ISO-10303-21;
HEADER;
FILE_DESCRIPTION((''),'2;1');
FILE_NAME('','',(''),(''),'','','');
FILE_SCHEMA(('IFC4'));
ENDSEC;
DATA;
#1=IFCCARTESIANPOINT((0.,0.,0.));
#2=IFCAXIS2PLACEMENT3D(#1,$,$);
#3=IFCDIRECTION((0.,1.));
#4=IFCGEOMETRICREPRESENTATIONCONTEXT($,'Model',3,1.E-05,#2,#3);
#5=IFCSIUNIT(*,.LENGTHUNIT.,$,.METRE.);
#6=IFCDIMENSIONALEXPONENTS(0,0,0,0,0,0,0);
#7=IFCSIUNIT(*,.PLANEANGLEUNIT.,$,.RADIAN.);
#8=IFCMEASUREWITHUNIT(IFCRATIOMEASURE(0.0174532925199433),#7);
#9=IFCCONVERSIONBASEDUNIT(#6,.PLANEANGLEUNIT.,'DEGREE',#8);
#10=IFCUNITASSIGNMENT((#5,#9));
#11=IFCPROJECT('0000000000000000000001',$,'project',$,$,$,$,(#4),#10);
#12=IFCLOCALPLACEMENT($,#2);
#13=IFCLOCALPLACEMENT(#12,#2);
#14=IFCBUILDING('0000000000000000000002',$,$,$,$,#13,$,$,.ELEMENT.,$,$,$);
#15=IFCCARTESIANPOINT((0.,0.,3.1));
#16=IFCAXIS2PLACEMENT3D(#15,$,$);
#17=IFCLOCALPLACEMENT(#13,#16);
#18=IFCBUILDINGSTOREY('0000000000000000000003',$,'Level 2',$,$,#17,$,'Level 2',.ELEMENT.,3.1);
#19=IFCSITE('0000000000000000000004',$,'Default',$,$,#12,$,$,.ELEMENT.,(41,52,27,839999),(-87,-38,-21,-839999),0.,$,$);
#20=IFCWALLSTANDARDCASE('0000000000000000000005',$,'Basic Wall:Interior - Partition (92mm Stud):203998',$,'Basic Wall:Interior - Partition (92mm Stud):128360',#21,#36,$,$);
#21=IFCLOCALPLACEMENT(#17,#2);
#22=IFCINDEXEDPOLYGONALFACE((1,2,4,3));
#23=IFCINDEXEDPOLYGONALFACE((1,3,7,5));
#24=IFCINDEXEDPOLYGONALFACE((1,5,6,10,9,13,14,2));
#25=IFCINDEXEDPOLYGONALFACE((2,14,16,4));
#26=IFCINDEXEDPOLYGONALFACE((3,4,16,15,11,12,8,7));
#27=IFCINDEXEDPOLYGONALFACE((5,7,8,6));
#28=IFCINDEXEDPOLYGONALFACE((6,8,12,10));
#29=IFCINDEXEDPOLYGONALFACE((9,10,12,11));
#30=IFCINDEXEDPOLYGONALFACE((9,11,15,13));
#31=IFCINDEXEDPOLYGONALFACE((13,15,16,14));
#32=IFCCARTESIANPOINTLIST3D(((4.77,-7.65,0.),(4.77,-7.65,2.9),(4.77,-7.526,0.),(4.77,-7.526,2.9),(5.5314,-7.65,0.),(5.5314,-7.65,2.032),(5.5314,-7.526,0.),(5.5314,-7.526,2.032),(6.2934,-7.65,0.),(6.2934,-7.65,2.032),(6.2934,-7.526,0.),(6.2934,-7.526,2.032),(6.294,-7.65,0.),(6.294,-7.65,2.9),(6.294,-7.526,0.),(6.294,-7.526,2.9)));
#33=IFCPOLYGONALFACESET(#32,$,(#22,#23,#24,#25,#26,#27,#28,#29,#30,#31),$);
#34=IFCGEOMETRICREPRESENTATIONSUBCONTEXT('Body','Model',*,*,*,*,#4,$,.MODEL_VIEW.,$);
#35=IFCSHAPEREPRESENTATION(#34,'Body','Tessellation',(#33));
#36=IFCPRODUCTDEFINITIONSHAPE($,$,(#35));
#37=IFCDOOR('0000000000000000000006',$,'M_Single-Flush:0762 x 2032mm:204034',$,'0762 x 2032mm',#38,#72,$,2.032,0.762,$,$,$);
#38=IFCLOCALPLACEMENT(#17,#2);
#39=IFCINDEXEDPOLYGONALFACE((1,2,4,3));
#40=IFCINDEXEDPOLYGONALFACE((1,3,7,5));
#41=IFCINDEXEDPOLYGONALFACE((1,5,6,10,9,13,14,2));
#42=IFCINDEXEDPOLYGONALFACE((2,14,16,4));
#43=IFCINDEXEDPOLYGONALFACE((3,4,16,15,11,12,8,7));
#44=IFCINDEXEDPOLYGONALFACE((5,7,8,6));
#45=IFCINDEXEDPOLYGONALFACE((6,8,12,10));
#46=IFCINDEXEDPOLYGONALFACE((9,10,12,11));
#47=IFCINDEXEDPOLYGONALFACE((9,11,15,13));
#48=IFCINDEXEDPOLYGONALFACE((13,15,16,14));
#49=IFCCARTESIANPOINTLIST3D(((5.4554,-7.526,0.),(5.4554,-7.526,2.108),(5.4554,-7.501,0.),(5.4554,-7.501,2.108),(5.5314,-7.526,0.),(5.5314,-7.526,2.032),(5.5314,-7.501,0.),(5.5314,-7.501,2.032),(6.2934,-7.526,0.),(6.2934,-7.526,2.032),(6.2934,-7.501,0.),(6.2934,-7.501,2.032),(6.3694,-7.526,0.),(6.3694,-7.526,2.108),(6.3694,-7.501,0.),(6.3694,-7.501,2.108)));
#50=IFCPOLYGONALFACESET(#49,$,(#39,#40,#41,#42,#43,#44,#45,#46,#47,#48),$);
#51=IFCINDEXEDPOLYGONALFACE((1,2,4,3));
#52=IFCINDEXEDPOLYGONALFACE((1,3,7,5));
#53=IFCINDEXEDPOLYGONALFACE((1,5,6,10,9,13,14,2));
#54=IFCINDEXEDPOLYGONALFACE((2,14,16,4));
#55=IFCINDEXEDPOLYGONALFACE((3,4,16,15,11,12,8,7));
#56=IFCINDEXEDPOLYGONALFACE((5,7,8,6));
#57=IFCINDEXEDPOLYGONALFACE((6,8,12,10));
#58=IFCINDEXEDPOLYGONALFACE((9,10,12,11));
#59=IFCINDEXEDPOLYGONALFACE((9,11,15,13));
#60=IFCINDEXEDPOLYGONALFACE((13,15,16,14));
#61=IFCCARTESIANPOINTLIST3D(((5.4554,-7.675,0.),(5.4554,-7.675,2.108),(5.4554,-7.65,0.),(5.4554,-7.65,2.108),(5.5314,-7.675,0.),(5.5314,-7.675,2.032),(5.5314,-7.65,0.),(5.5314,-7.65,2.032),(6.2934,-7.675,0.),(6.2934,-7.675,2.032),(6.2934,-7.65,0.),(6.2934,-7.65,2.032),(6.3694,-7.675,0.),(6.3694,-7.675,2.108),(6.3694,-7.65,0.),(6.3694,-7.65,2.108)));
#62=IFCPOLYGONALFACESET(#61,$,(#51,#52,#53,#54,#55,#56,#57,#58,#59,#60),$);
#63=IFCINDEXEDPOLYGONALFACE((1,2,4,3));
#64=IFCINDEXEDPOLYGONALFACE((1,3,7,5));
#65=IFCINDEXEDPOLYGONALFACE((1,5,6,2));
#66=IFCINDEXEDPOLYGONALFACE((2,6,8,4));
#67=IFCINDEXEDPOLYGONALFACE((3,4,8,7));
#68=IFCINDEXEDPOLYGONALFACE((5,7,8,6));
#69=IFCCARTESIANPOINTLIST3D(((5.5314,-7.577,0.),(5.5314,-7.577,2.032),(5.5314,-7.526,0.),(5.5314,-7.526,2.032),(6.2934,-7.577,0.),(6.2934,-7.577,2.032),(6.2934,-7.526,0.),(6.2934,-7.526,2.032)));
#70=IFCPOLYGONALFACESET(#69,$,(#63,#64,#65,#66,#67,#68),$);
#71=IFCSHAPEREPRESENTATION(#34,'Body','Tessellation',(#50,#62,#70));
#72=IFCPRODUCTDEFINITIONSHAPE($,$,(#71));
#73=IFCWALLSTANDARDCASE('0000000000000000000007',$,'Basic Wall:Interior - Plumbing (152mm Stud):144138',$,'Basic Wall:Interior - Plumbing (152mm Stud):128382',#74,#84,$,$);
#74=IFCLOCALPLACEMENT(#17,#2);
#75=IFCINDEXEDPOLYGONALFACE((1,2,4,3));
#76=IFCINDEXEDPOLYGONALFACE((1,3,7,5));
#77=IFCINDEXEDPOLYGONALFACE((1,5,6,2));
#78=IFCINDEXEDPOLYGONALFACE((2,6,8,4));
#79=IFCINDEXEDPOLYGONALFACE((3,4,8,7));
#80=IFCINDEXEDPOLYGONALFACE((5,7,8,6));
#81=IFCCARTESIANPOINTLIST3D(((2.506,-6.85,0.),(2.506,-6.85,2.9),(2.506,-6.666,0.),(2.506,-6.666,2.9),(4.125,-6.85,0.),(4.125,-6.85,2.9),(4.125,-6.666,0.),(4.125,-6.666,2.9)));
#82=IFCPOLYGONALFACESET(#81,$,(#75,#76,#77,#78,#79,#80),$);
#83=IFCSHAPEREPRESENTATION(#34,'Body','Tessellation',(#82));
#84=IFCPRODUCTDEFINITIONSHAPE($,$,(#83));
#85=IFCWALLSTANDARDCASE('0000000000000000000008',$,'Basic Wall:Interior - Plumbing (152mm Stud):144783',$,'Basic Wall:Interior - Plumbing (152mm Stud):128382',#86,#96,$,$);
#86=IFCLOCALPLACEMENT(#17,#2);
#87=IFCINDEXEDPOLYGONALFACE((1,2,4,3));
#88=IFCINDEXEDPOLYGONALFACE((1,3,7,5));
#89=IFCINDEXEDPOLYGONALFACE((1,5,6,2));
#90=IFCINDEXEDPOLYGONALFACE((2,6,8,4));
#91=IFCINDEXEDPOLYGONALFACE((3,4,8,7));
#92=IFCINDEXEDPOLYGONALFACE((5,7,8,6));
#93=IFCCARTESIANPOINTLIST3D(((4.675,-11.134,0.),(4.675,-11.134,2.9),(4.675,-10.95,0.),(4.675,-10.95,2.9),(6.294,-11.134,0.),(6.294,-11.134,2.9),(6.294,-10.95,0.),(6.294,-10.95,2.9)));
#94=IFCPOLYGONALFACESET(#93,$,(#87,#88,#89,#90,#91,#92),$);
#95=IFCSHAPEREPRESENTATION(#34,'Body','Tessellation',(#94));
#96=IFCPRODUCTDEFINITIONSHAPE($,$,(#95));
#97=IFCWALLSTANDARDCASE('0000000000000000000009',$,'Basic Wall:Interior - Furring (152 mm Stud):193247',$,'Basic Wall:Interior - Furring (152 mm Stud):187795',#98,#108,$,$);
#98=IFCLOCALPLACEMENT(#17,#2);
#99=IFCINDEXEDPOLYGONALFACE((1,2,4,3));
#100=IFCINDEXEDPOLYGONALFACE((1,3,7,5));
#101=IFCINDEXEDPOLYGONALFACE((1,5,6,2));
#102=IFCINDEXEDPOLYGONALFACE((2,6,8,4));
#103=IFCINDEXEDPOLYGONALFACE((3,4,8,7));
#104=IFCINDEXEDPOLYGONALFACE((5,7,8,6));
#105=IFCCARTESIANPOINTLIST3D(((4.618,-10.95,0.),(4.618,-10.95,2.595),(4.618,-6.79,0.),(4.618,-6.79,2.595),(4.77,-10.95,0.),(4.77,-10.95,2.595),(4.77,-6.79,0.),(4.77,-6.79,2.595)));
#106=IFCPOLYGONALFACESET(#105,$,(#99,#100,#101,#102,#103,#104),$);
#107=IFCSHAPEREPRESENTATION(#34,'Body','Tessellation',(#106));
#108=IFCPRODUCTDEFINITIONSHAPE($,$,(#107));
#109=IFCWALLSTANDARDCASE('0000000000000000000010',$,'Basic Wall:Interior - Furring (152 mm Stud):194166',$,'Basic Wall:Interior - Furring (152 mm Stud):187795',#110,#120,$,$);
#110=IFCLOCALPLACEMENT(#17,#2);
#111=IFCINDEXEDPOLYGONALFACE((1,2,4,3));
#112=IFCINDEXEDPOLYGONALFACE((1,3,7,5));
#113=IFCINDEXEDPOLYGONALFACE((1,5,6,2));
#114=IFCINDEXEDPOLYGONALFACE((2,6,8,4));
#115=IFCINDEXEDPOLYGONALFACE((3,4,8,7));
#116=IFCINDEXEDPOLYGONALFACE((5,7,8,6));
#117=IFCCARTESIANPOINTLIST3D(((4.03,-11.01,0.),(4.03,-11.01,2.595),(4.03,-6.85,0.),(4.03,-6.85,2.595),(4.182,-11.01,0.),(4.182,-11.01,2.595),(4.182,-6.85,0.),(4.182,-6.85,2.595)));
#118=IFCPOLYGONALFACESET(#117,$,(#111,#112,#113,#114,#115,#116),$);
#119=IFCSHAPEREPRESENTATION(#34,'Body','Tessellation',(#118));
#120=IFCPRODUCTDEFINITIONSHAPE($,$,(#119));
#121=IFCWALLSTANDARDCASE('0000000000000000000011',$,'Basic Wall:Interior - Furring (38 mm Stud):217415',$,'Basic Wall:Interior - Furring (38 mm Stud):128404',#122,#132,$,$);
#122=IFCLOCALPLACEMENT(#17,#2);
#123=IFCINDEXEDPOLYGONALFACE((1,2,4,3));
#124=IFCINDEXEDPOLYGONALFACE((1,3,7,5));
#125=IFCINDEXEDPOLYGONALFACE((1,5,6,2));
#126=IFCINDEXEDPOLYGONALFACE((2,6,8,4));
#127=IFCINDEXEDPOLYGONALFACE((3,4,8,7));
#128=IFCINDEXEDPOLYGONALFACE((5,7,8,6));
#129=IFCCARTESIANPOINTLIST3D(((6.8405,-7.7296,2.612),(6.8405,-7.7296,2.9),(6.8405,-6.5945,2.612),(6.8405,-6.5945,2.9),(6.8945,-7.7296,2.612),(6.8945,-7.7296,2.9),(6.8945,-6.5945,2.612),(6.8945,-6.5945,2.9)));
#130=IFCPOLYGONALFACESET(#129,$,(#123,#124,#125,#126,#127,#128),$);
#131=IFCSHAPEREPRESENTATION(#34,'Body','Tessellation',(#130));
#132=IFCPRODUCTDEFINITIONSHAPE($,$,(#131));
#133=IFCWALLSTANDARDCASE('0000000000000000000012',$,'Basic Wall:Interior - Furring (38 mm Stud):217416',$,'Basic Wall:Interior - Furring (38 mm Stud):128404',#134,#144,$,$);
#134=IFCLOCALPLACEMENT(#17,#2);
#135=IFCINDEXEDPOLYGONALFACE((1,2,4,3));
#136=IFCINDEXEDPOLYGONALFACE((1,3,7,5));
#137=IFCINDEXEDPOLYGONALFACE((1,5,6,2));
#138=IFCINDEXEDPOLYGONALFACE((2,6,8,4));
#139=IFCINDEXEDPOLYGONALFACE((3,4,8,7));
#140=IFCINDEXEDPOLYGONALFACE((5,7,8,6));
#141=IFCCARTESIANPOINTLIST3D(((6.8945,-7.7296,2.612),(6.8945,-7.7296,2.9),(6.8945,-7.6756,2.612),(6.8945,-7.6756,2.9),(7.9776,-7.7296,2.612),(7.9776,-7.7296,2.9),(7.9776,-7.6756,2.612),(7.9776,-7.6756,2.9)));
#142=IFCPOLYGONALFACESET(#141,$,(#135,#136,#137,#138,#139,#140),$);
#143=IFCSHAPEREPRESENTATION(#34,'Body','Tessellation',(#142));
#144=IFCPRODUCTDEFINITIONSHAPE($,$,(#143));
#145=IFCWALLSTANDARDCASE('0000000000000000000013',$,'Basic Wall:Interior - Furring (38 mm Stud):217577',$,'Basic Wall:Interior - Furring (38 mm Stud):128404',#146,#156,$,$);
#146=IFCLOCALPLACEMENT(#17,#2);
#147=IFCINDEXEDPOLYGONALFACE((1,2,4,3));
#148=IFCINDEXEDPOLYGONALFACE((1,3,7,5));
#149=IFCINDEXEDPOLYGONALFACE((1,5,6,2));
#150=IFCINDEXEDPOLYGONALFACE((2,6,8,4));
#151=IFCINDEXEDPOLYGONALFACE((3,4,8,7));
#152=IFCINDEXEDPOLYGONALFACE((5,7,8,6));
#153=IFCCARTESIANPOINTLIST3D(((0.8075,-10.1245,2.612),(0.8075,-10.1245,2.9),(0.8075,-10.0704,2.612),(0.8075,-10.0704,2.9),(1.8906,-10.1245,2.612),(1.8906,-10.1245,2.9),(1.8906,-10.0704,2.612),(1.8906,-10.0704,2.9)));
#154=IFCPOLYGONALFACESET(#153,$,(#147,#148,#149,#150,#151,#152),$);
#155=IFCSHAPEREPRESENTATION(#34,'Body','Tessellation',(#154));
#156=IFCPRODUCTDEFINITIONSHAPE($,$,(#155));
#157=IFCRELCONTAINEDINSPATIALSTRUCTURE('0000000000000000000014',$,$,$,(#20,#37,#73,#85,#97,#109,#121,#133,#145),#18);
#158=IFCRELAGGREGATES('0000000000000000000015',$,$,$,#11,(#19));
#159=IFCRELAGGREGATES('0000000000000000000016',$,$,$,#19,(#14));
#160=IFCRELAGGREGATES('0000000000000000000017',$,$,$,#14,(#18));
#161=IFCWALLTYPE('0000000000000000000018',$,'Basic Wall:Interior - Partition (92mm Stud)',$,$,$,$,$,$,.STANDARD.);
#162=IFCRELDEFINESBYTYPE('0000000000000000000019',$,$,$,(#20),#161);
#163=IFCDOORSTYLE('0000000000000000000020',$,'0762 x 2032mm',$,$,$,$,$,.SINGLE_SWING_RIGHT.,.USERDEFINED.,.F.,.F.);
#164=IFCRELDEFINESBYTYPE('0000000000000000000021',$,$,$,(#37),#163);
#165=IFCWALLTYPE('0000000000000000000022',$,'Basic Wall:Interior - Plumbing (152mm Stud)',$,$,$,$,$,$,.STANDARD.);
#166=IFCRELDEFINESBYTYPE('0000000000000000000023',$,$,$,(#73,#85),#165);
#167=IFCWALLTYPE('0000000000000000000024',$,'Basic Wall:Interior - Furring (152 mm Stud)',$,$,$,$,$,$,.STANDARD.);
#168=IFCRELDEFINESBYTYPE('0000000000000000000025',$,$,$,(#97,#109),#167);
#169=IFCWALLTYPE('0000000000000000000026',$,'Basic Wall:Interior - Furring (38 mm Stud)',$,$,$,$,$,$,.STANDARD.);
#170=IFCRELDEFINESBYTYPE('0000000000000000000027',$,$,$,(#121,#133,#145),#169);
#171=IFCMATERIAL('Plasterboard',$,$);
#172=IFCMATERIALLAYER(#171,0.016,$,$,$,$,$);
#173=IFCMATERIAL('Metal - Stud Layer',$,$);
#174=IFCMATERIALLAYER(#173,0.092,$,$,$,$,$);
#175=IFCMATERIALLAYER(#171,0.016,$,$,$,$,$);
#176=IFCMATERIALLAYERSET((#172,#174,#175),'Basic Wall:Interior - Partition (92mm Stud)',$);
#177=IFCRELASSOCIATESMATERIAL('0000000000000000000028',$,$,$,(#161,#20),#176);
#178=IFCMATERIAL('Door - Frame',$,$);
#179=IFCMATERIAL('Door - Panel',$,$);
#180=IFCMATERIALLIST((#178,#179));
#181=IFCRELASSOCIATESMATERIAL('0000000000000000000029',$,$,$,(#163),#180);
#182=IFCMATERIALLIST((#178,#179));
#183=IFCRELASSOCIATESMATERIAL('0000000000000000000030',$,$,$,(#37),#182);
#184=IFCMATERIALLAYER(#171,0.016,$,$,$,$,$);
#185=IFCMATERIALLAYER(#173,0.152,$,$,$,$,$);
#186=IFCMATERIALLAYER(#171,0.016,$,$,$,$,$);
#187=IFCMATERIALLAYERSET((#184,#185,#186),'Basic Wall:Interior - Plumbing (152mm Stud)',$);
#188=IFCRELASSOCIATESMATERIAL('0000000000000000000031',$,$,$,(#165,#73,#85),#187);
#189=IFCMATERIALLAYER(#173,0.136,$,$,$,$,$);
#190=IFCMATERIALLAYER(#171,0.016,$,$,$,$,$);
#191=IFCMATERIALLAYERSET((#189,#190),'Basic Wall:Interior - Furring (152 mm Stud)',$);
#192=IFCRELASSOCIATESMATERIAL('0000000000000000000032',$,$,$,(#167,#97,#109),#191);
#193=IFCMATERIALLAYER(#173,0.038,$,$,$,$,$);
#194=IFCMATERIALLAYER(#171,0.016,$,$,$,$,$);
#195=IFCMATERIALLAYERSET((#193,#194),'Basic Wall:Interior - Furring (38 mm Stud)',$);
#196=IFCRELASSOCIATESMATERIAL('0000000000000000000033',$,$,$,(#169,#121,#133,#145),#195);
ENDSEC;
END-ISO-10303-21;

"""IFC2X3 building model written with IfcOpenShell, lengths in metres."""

from ifc_helpers import new_model, entity, si_unit, converted_unit, direction, frame, frame_2d, origin, origin_2d_with_axis, place, context, subcontext, project, spatial, polyline, rectangle, outline, extrude, source, transform, mapped, material, material_list, layer, layer_set, layer_usage, type_object, type_shapes, element, fill, save


model = new_model("IFC2X3")

# Units and contexts
model_context = context("Model", 3, precision=1e-05, world=origin(), true_north=direction((0.0, 1.0)))
body_context = subcontext(model_context, "Body", "Model", "MODEL_VIEW")
ifc_project = project(units=[si_unit("LENGTHUNIT", "METRE"), converted_unit("PLANEANGLEUNIT", "DEGREE", entity("IfcRatioMeasure", 0.0174532925199433), si_unit("PLANEANGLEUNIT", "RADIAN"), dimensions=[0, 0, 0, 0, 0, 0, 0])], contexts=[model_context])

# Site, building, storey
site_placement = place(None, origin())
site = spatial("IfcSite", under=ifc_project, at=site_placement, Name="Default", CompositionType="ELEMENT", RefLatitude=(41, 52, 27, 839999), RefLongitude=(-87, -38, -21, -839999), RefElevation=0.0)
building_placement = place(site_placement, origin())
building = spatial("IfcBuilding", under=site, at=building_placement, CompositionType="ELEMENT")
storey_placement = place(building_placement, frame((0.0, 0.0, 3.1)))
storey = spatial("IfcBuildingStorey", under=building, at=storey_placement, Name="Level 2", LongName="Level 2", CompositionType="ELEMENT", Elevation=3.1)

# Shared definitions
ifc_material_1 = material(Name="Plasterboard")
ifc_layer_1 = layer(ifc_material_1, 0.016)
ifc_material_2 = material(Name="Metal - Stud Layer")
ifc_layer_2 = layer(ifc_material_2, 0.092)
ifc_layer_3 = layer(ifc_material_1, 0.016)
ifc_layer_set_1 = layer_set([ifc_layer_1, ifc_layer_2, ifc_layer_3], Name="Basic Wall:Interior - Partition (92mm Stud)")
wall_type_1 = type_object("IfcWallType", Name="Basic Wall:Interior - Partition (92mm Stud)", PredefinedType="STANDARD", material=ifc_layer_set_1)

# Wall, opening, door
ifc_material_3 = material(Name="Door - Frame")
ifc_material_4 = material(Name="Door - Panel")
ifc_material_list_1 = material_list([ifc_material_3, ifc_material_4])
door_style = type_object("IfcDoorStyle", Name="0762 x 2032mm", ConstructionType="USERDEFINED", OperationType="SINGLE_SWING_RIGHT", ParameterTakesPrecedence=False, Sizeable=False, material=ifc_material_list_1)
shared_shape_1 = source(origin(), body_context, "Body", "SweptSolid", [
    extrude(outline(polyline([(-0.457, -1.073), (0.457, -1.073), (0.457, 1.035), (0.381, 1.035), (0.381, -0.997), (-0.381, -0.997), (-0.381, 1.035), (-0.457, 1.035), (-0.457, -1.073)])), frame((0.381, 0.124, 1.035), z_axis=(0.0, 1.0, 0.0), x_axis=(1.0, 0.0, 0.0)), (0.0, 0.0, 1.0), 0.025),
    extrude(outline(polyline([(-1.073, -0.457), (1.035, -0.457), (1.035, -0.381), (-0.997, -0.381), (-0.997, 0.381), (1.035, 0.381), (1.035, 0.457), (-1.073, 0.457), (-1.073, -0.457)])), frame((0.381, -0.025, 1.035), z_axis=(0.0, 1.0, 0.0), x_axis=(0.0, 0.0, -1.0)), (0.0, 0.0, 1.0), 0.025),
    extrude(rectangle(XDim=0.051, YDim=0.762, at=origin_2d_with_axis()), frame((0.381, 0.0985, 0.0), z_axis=(0.0, 0.0, 1.0), x_axis=(0.0, 1.0, 0.0)), (0.0, 0.0, 1.0), 2.032),
])
type_shapes(door_style, [shared_shape_1])
ifc_layer_usage_1 = layer_usage(ifc_layer_set_1, "AXIS2", "POSITIVE", -0.062)
wall_1_placement = place(storey_placement, frame((4.77, -7.588, 0.0)))
wall_1 = element("IfcWallStandardCase", 1, at=wall_1_placement, inside=storey, type_object=wall_type_1, material=ifc_layer_usage_1, Name="Basic Wall:Interior - Partition (92mm Stud):203998", ObjectType="Basic Wall:Interior - Partition (92mm Stud):128360", context=body_context, shape_type="SweptSolid", body=[
    extrude(rectangle(XDim=1.524, YDim=0.124, at=frame_2d((0.762, 0.0), x_axis=(-1.0, 0.0))), origin(), (0.0, 0.0, 1.0), 2.9),
])
opening_1_placement = place(wall_1_placement, frame((0.7614, -0.062, 0.0)))
opening_1 = element("IfcOpeningElement", 2, at=opening_1_placement, cuts=wall_1, ObjectType="Opening", context=body_context, shape_type="SweptSolid", body=[
    extrude(rectangle(XDim=0.762, YDim=2.032, at=frame_2d((1.016, 0.381), x_axis=(0.0, 1.0))), frame((0.0, 0.0, 0.0), z_axis=(0.0, 1.0, 0.0), x_axis=(0.0, 0.0, 1.0)), (0.0, 0.0, 1.0), 0.124),
])
ifc_material_list_2 = material_list([ifc_material_3, ifc_material_4])
door_1_placement = place(opening_1_placement, origin())
door_1 = element("IfcDoor", 3, at=door_1_placement, inside=storey, type_object=door_style, material=ifc_material_list_2, Name="M_Single-Flush:0762 x 2032mm:204034", ObjectType="0762 x 2032mm", OverallHeight=2.032, OverallWidth=0.762, context=body_context, shape_type="MappedRepresentation", body=[
    mapped(shared_shape_1, transform((0.0, 0.0, 0.0), scale=1.0)),
])
fill(opening_1, door_1)

# Walls
ifc_layer_4 = layer(ifc_material_1, 0.016)
ifc_layer_5 = layer(ifc_material_2, 0.152)
ifc_layer_6 = layer(ifc_material_1, 0.016)
ifc_layer_set_2 = layer_set([ifc_layer_4, ifc_layer_5, ifc_layer_6], Name="Basic Wall:Interior - Plumbing (152mm Stud)")
ifc_layer_usage_2 = layer_usage(ifc_layer_set_2, "AXIS2", "NEGATIVE", 0.092)
wall_type_2 = type_object("IfcWallType", Name="Basic Wall:Interior - Plumbing (152mm Stud)", PredefinedType="STANDARD", material=ifc_layer_set_2)
wall_2_placement = place(storey_placement, frame((2.506, -6.758, 0.0)))
element("IfcWallStandardCase", 4, at=wall_2_placement, inside=storey, type_object=wall_type_2, material=ifc_layer_usage_2, Name="Basic Wall:Interior - Plumbing (152mm Stud):144138", ObjectType="Basic Wall:Interior - Plumbing (152mm Stud):128382", context=body_context, shape_type="SweptSolid", body=[
    extrude(rectangle(XDim=1.619, YDim=0.184, at=frame_2d((0.8095, 0.0), x_axis=(-1.0, 0.0))), origin(), (0.0, 0.0, 1.0), 2.9),
])
ifc_layer_usage_3 = layer_usage(ifc_layer_set_2, "AXIS2", "NEGATIVE", 0.092)
wall_3_placement = place(storey_placement, frame((6.294, -11.042, 0.0), z_axis=(0.0, 0.0, 1.0), x_axis=(-1.0, 0.0, 0.0)))
element("IfcWallStandardCase", 5, at=wall_3_placement, inside=storey, type_object=wall_type_2, material=ifc_layer_usage_3, Name="Basic Wall:Interior - Plumbing (152mm Stud):144783", ObjectType="Basic Wall:Interior - Plumbing (152mm Stud):128382", context=body_context, shape_type="SweptSolid", body=[
    extrude(rectangle(XDim=1.619, YDim=0.184, at=frame_2d((0.8095, 0.0), x_axis=(-1.0, 0.0))), origin(), (0.0, 0.0, 1.0), 2.9),
])
ifc_layer_7 = layer(ifc_material_2, 0.136)
ifc_layer_8 = layer(ifc_material_1, 0.016)
ifc_layer_set_3 = layer_set([ifc_layer_7, ifc_layer_8], Name="Basic Wall:Interior - Furring (152 mm Stud)")
ifc_layer_usage_4 = layer_usage(ifc_layer_set_3, "AXIS2", "POSITIVE", -0.076)
wall_type_3 = type_object("IfcWallType", Name="Basic Wall:Interior - Furring (152 mm Stud)", PredefinedType="STANDARD", material=ifc_layer_set_3)
wall_4_placement = place(storey_placement, frame((4.694, -6.79, 0.0), z_axis=(0.0, 0.0, 1.0), x_axis=(0.0, -1.0, 0.0)))
element("IfcWallStandardCase", 6, at=wall_4_placement, inside=storey, type_object=wall_type_3, material=ifc_layer_usage_4, Name="Basic Wall:Interior - Furring (152 mm Stud):193247", ObjectType="Basic Wall:Interior - Furring (152 mm Stud):187795", context=body_context, shape_type="SweptSolid", body=[
    extrude(rectangle(XDim=4.16, YDim=0.152, at=frame_2d((2.08, 0.0), x_axis=(-1.0, 0.0))), origin(), (0.0, 0.0, 1.0), 2.595),
])
ifc_layer_usage_5 = layer_usage(ifc_layer_set_3, "AXIS2", "POSITIVE", -0.076)
wall_5_placement = place(storey_placement, frame((4.106, -11.01, 0.0), z_axis=(0.0, 0.0, 1.0), x_axis=(0.0, 1.0, 0.0)))
element("IfcWallStandardCase", 7, at=wall_5_placement, inside=storey, type_object=wall_type_3, material=ifc_layer_usage_5, Name="Basic Wall:Interior - Furring (152 mm Stud):194166", ObjectType="Basic Wall:Interior - Furring (152 mm Stud):187795", context=body_context, shape_type="SweptSolid", body=[
    extrude(rectangle(XDim=4.16, YDim=0.152, at=frame_2d((2.08, 0.0), x_axis=(-1.0, 0.0))), origin(), (0.0, 0.0, 1.0), 2.595),
])
ifc_layer_9 = layer(ifc_material_2, 0.038)
ifc_layer_10 = layer(ifc_material_1, 0.016)
ifc_layer_set_4 = layer_set([ifc_layer_9, ifc_layer_10], Name="Basic Wall:Interior - Furring (38 mm Stud)")
ifc_layer_usage_6 = layer_usage(ifc_layer_set_4, "AXIS2", "NEGATIVE", 0.027)
wall_type_4 = type_object("IfcWallType", Name="Basic Wall:Interior - Furring (38 mm Stud)", PredefinedType="STANDARD", material=ifc_layer_set_4)
wall_6_placement = place(storey_placement, frame((6.8675, -7.7296, 2.612), z_axis=(0.0, 0.0, 1.0), x_axis=(0.0, 1.0, 0.0)))
element("IfcWallStandardCase", 8, at=wall_6_placement, inside=storey, type_object=wall_type_4, material=ifc_layer_usage_6, Name="Basic Wall:Interior - Furring (38 mm Stud):217415", ObjectType="Basic Wall:Interior - Furring (38 mm Stud):128404", context=body_context, shape_type="SweptSolid", body=[
    extrude(rectangle(XDim=1.1351, YDim=0.054, at=frame_2d((0.5675, 0.0), x_axis=(-1.0, 0.0))), origin(), (0.0, 0.0, 1.0), 0.288),
])
ifc_layer_usage_7 = layer_usage(ifc_layer_set_4, "AXIS2", "NEGATIVE", 0.027)
wall_7_placement = place(storey_placement, frame((7.9776, -7.7026, 2.612), z_axis=(0.0, 0.0, 1.0), x_axis=(-1.0, 0.0, 0.0)))
element("IfcWallStandardCase", 9, at=wall_7_placement, inside=storey, type_object=wall_type_4, material=ifc_layer_usage_7, Name="Basic Wall:Interior - Furring (38 mm Stud):217416", ObjectType="Basic Wall:Interior - Furring (38 mm Stud):128404", context=body_context, shape_type="SweptSolid", body=[
    extrude(rectangle(XDim=1.0831, YDim=0.054, at=frame_2d((0.5415, 0.0), x_axis=(-1.0, 0.0))), origin(), (0.0, 0.0, 1.0), 0.288),
])
ifc_layer_usage_8 = layer_usage(ifc_layer_set_4, "AXIS2", "NEGATIVE", 0.027)
wall_8_placement = place(storey_placement, frame((0.8075, -10.0975, 2.612)))
element("IfcWallStandardCase", 10, at=wall_8_placement, inside=storey, type_object=wall_type_4, material=ifc_layer_usage_8, Name="Basic Wall:Interior - Furring (38 mm Stud):217577", ObjectType="Basic Wall:Interior - Furring (38 mm Stud):128404", context=body_context, shape_type="SweptSolid", body=[
    extrude(rectangle(XDim=1.0831, YDim=0.054, at=frame_2d((0.5415, 0.0), x_axis=(-1.0, 0.0))), origin(), (0.0, 0.0, 1.0), 0.288),
])

save(model, "model.ifc")
